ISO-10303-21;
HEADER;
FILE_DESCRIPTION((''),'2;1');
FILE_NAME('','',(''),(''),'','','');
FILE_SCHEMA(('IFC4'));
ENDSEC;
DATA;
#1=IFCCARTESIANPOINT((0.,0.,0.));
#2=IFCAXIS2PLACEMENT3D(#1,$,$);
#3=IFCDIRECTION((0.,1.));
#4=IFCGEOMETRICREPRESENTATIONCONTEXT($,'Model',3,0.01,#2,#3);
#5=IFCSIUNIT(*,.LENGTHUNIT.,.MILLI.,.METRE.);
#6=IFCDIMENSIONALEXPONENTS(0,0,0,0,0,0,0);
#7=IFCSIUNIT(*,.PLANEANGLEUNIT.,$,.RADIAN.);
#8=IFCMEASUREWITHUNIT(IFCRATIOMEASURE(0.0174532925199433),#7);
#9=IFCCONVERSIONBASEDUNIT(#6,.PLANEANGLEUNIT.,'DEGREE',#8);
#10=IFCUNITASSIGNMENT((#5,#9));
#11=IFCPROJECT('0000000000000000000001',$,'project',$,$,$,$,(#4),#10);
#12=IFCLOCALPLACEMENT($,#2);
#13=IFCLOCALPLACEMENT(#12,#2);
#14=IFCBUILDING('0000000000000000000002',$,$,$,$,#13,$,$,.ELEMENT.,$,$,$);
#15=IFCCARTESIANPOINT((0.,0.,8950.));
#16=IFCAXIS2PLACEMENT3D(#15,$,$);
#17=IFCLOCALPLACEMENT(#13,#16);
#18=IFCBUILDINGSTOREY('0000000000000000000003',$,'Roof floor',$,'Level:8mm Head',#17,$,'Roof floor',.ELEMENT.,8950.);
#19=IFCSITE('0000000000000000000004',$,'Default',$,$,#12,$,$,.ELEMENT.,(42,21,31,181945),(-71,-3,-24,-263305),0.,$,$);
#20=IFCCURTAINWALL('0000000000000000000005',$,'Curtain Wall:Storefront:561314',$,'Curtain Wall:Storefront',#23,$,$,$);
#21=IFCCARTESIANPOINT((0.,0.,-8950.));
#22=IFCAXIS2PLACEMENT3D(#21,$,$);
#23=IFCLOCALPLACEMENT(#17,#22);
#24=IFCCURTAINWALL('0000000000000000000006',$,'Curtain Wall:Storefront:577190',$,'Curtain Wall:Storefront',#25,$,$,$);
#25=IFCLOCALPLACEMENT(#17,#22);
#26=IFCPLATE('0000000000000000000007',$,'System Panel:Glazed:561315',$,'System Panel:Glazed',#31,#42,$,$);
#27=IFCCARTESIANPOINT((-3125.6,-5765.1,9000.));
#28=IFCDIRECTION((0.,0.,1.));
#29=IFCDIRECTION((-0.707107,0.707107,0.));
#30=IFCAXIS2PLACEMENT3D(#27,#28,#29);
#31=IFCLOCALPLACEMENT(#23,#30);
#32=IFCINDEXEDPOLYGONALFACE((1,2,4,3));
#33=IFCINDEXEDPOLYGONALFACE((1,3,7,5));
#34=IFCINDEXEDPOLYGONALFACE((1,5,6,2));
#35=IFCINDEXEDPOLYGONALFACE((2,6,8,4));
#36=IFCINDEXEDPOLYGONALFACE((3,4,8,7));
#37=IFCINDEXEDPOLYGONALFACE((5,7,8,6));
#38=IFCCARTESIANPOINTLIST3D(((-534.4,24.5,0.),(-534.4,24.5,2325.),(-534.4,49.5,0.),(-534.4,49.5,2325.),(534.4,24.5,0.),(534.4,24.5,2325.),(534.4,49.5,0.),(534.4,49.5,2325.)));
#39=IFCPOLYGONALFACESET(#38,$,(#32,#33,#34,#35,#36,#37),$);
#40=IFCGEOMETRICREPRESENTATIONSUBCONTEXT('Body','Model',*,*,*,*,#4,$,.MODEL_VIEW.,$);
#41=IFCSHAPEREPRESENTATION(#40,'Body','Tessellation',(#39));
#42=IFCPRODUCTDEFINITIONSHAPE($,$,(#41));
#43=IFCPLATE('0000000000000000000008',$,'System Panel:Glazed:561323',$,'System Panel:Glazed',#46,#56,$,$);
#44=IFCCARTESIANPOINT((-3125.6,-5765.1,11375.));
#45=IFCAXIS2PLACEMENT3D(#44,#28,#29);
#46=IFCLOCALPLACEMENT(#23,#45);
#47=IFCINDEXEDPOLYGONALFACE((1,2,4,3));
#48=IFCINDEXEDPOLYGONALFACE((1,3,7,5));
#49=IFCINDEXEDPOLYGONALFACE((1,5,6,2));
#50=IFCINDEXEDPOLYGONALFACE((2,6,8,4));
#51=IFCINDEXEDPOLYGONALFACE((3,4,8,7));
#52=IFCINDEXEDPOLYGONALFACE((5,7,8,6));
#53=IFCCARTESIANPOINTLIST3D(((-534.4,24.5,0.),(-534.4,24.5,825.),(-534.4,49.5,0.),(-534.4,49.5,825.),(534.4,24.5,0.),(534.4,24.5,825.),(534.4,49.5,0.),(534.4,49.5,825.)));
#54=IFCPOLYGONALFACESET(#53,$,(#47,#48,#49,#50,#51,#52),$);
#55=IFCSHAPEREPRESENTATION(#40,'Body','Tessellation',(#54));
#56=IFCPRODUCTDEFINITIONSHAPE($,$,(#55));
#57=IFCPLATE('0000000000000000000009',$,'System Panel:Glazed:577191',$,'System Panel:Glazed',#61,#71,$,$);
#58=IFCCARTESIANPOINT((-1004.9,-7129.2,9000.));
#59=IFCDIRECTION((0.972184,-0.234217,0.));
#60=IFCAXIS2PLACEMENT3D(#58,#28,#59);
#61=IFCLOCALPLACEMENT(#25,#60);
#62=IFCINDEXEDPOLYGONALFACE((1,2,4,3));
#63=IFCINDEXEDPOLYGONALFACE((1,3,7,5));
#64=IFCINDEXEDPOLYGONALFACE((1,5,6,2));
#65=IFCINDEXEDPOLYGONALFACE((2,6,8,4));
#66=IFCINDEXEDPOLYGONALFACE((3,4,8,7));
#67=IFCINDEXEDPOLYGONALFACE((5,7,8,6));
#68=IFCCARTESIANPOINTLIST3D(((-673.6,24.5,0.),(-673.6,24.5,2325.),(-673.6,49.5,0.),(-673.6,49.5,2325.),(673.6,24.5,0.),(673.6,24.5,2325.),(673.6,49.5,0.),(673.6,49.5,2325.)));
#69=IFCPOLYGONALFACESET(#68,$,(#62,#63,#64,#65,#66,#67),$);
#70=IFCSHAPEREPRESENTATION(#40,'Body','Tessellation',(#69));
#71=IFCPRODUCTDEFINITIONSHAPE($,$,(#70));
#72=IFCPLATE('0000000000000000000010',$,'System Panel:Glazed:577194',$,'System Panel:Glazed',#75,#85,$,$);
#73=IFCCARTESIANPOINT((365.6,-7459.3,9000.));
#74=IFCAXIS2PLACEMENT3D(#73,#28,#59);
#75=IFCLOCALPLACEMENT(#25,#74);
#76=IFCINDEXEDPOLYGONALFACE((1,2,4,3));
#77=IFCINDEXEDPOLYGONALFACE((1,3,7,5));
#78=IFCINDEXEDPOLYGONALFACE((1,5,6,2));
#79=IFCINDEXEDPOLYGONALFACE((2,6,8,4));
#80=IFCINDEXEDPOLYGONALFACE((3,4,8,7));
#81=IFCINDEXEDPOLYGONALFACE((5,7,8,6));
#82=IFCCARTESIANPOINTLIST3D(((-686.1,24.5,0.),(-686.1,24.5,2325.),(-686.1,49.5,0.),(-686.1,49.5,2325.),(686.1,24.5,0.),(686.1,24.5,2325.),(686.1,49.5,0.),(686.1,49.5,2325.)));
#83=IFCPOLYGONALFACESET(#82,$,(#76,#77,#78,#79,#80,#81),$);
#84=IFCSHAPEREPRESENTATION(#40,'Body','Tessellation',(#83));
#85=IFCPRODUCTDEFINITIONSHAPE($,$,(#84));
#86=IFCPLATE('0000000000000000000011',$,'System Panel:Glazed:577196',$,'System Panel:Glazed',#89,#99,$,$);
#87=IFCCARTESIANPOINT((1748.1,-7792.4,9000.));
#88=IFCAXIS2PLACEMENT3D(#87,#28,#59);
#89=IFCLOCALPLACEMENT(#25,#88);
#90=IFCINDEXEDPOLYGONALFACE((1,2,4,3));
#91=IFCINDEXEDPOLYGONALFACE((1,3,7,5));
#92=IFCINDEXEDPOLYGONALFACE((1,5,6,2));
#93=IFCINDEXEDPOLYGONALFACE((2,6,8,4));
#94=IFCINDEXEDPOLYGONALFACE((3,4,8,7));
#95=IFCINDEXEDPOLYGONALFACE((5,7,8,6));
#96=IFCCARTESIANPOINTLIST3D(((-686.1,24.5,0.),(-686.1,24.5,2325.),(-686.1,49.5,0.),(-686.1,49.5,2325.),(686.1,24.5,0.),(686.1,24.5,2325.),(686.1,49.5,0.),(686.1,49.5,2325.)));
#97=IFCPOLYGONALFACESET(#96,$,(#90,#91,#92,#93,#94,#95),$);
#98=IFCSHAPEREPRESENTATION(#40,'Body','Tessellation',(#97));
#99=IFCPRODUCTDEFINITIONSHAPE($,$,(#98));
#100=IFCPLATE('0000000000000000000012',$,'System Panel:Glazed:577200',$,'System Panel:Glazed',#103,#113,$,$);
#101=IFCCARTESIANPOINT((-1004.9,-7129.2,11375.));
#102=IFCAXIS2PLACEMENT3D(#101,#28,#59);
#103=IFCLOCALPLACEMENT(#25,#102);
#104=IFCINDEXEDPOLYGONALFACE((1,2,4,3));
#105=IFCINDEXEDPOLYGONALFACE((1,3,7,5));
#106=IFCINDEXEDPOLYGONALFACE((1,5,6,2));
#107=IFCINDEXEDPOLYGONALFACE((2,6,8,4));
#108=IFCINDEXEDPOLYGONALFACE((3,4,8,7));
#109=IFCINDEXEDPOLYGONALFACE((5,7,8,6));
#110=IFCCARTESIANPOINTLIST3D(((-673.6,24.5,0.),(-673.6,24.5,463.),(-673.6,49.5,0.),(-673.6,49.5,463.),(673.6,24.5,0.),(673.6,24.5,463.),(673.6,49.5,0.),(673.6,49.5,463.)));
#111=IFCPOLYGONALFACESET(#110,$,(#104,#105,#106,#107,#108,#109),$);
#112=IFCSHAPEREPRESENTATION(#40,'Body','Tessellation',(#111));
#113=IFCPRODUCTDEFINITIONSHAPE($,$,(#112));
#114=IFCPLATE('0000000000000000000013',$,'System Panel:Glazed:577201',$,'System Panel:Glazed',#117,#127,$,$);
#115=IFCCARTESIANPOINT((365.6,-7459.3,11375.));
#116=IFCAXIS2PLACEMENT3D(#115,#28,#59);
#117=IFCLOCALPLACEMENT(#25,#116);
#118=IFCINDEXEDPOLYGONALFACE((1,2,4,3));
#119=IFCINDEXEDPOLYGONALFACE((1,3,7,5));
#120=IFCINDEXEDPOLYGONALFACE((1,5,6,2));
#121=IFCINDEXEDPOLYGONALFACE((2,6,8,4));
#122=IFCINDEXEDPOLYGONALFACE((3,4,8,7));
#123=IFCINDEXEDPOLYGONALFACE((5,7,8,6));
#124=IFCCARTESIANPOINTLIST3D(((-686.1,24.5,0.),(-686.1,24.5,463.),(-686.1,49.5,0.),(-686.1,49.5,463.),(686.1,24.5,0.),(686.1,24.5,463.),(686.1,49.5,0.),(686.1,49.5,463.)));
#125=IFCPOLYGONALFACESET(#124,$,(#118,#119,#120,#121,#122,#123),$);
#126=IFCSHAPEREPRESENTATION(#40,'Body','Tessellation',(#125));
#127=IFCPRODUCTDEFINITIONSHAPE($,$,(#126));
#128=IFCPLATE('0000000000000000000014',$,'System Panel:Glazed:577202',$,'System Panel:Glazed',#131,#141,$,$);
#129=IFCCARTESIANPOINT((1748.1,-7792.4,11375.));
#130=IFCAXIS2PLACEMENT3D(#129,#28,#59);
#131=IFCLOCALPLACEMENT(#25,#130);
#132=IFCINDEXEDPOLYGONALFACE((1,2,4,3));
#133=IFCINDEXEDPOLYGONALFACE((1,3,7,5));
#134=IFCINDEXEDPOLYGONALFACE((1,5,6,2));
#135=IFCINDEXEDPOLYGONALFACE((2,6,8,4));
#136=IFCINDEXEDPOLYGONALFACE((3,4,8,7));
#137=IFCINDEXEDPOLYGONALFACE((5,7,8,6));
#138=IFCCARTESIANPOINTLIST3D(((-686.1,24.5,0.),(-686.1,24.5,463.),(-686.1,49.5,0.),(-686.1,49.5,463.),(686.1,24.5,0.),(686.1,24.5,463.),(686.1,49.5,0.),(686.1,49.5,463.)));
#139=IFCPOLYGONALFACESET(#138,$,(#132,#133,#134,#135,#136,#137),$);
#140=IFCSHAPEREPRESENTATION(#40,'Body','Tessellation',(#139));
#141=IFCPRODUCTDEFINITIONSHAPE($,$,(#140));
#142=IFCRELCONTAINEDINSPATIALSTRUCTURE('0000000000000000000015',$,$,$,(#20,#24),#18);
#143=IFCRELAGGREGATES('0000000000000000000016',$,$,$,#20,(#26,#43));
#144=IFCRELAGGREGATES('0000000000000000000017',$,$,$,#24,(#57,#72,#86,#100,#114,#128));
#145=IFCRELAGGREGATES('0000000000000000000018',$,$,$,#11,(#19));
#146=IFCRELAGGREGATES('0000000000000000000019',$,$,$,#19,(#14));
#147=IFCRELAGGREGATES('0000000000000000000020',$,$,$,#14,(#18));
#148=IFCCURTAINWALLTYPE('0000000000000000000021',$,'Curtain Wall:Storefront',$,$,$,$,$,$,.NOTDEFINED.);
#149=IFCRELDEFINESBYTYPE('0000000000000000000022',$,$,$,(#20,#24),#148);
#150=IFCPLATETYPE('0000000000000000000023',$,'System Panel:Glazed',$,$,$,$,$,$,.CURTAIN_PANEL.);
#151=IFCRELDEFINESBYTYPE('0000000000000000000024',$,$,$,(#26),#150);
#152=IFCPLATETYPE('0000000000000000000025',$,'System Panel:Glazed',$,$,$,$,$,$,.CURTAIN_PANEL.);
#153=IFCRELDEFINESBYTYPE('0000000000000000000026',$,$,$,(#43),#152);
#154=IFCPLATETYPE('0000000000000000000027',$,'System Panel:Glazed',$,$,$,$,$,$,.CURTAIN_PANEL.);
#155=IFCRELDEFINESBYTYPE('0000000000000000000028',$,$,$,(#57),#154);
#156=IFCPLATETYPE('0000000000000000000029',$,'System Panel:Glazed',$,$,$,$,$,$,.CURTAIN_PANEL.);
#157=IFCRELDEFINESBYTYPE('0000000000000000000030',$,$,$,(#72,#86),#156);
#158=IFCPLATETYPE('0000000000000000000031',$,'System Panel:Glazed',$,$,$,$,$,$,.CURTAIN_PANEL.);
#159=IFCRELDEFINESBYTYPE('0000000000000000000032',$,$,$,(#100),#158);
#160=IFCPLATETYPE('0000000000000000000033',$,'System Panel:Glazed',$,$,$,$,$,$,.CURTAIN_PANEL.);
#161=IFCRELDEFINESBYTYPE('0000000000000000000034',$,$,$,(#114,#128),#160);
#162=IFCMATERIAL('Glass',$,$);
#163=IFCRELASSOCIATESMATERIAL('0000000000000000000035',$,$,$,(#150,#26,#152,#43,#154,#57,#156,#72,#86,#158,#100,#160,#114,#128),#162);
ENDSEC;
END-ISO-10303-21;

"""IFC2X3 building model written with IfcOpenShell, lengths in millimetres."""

from ifc_helpers import new_model, entity, si_unit, converted_unit, direction, frame, frame_2d, origin, origin_2d_with_axis, place, context, subcontext, project, spatial, rectangle, extrude, source, transform, mapped, material, type_object, type_shapes, element, aggregate, save


model = new_model("IFC2X3")

# Units and contexts
model_context = context("Model", 3, precision=0.01, world=origin(), true_north=direction((0.0, 1.0)))
body_context = subcontext(model_context, "Body", "Model", "MODEL_VIEW")
ifc_project = project(units=[si_unit("LENGTHUNIT", "METRE", prefix="MILLI"), converted_unit("PLANEANGLEUNIT", "DEGREE", entity("IfcRatioMeasure", 0.0174532925199433), si_unit("PLANEANGLEUNIT", "RADIAN"), dimensions=[0, 0, 0, 0, 0, 0, 0])], contexts=[model_context])

# Site, building, storey
site_placement = place(None, origin())
site = spatial("IfcSite", under=ifc_project, at=site_placement, Name="Default", CompositionType="ELEMENT", RefLatitude=(42, 21, 31, 181945), RefLongitude=(-71, -3, -24, -263305), RefElevation=0.0)
building_placement = place(site_placement, origin())
building = spatial("IfcBuilding", under=site, at=building_placement, CompositionType="ELEMENT")
storey_placement = place(building_placement, frame((0.0, 0.0, 8950.0)))
storey = spatial("IfcBuildingStorey", under=building, at=storey_placement, Name="Roof floor", ObjectType="Level:8mm Head", LongName="Roof floor", CompositionType="ELEMENT", Elevation=8950.0)

# Curtain walls
curtain_wall_type = type_object("IfcCurtainWallType", Name="Curtain Wall:Storefront", PredefinedType="NOTDEFINED")
curtain_wall_1_placement = place(storey_placement, frame((0.0, 0.0, -8950.0)))
curtain_wall_1 = element("IfcCurtainWall", 1, at=curtain_wall_1_placement, inside=storey, type_object=curtain_wall_type, Name="Curtain Wall:Storefront:561314", ObjectType="Curtain Wall:Storefront")
curtain_wall_2_placement = place(storey_placement, frame((0.0, 0.0, -8950.0)))
curtain_wall_2 = element("IfcCurtainWall", 2, at=curtain_wall_2_placement, inside=storey, type_object=curtain_wall_type, Name="Curtain Wall:Storefront:577190", ObjectType="Curtain Wall:Storefront")

# Plates
ifc_material_1 = material(Name="Glass")
plate_type_1 = type_object("IfcPlateType", Name="System Panel:Glazed", PredefinedType="CURTAIN_PANEL", material=ifc_material_1)
shared_shape_1 = source(origin(), body_context, "Body", "SweptSolid", [
    extrude(rectangle(XDim=25.0, YDim=1068.7, at=frame_2d((0.0, 0.0), x_axis=(1.0, 0.0))), frame((0.0, 37.0, 0.0), z_axis=(0.0, 0.0, 1.0), x_axis=(0.0, 1.0, 0.0)), (0.0, 0.0, 1.0), 2325.0),
])
type_shapes(plate_type_1, [shared_shape_1])
plate_1_placement = place(curtain_wall_1_placement, frame((-3125.6, -5765.1, 9000.0), z_axis=(0.0, 0.0, 1.0), x_axis=(-0.707107, 0.707107, 0.0)))
plate_1 = element("IfcPlate", 3, at=plate_1_placement, type_object=plate_type_1, material=ifc_material_1, Name="System Panel:Glazed:561315", ObjectType="System Panel:Glazed", context=body_context, shape_type="MappedRepresentation", body=[
    mapped(shared_shape_1, transform((0.0, 0.0, 0.0), scale=1.0)),
])
plate_type_2 = type_object("IfcPlateType", Name="System Panel:Glazed", PredefinedType="CURTAIN_PANEL", material=ifc_material_1)
shared_shape_2 = source(origin(), body_context, "Body", "SweptSolid", [
    extrude(rectangle(XDim=25.0, YDim=1068.7, at=frame_2d((0.0, 0.0), x_axis=(1.0, 0.0))), frame((0.0, 37.0, 0.0), z_axis=(0.0, 0.0, 1.0), x_axis=(0.0, 1.0, 0.0)), (0.0, 0.0, 1.0), 825.0),
])
type_shapes(plate_type_2, [shared_shape_2])
plate_2_placement = place(curtain_wall_1_placement, frame((-3125.6, -5765.1, 11375.0), z_axis=(0.0, 0.0, 1.0), x_axis=(-0.707107, 0.707107, 0.0)))
plate_2 = element("IfcPlate", 4, at=plate_2_placement, type_object=plate_type_2, material=ifc_material_1, Name="System Panel:Glazed:561323", ObjectType="System Panel:Glazed", context=body_context, shape_type="MappedRepresentation", body=[
    mapped(shared_shape_2, transform((0.0, 0.0, 0.0), scale=1.0)),
])
aggregate(curtain_wall_1, [plate_1, plate_2])
plate_type_3 = type_object("IfcPlateType", Name="System Panel:Glazed", PredefinedType="CURTAIN_PANEL", material=ifc_material_1)
shared_shape_3 = source(origin(), body_context, "Body", "SweptSolid", [
    extrude(rectangle(XDim=25.0, YDim=1347.1, at=origin_2d_with_axis()), frame((0.0, 37.0, 0.0), z_axis=(0.0, 0.0, 1.0), x_axis=(0.0, 1.0, 0.0)), (0.0, 0.0, 1.0), 2325.0),
])
type_shapes(plate_type_3, [shared_shape_3])
plate_3_placement = place(curtain_wall_2_placement, frame((-1004.9, -7129.2, 9000.0), z_axis=(0.0, 0.0, 1.0), x_axis=(0.972184, -0.234217, 0.0)))
plate_3 = element("IfcPlate", 5, at=plate_3_placement, type_object=plate_type_3, material=ifc_material_1, Name="System Panel:Glazed:577191", ObjectType="System Panel:Glazed", context=body_context, shape_type="MappedRepresentation", body=[
    mapped(shared_shape_3, transform((0.0, 0.0, 0.0), scale=1.0)),
])
plate_type_4 = type_object("IfcPlateType", Name="System Panel:Glazed", PredefinedType="CURTAIN_PANEL", material=ifc_material_1)
shared_shape_4 = source(origin(), body_context, "Body", "SweptSolid", [
    extrude(rectangle(XDim=25.0, YDim=1372.1, at=origin_2d_with_axis()), frame((0.0, 37.0, 0.0), z_axis=(0.0, 0.0, 1.0), x_axis=(0.0, 1.0, 0.0)), (0.0, 0.0, 1.0), 2325.0),
])
type_shapes(plate_type_4, [shared_shape_4])
plate_4_placement = place(curtain_wall_2_placement, frame((365.6, -7459.3, 9000.0), z_axis=(0.0, 0.0, 1.0), x_axis=(0.972184, -0.234217, 0.0)))
plate_4 = element("IfcPlate", 6, at=plate_4_placement, type_object=plate_type_4, material=ifc_material_1, Name="System Panel:Glazed:577194", ObjectType="System Panel:Glazed", context=body_context, shape_type="MappedRepresentation", body=[
    mapped(shared_shape_4, transform((0.0, 0.0, 0.0), scale=1.0)),
])
plate_5_placement = place(curtain_wall_2_placement, frame((1748.1, -7792.4, 9000.0), z_axis=(0.0, 0.0, 1.0), x_axis=(0.972184, -0.234217, 0.0)))
plate_5 = element("IfcPlate", 7, at=plate_5_placement, type_object=plate_type_4, material=ifc_material_1, Name="System Panel:Glazed:577196", ObjectType="System Panel:Glazed", context=body_context, shape_type="MappedRepresentation", body=[
    mapped(shared_shape_4, transform((0.0, 0.0, 0.0), scale=1.0)),
])
plate_type_5 = type_object("IfcPlateType", Name="System Panel:Glazed", PredefinedType="CURTAIN_PANEL", material=ifc_material_1)
shared_shape_5 = source(origin(), body_context, "Body", "SweptSolid", [
    extrude(rectangle(XDim=25.0, YDim=1347.1, at=origin_2d_with_axis()), frame((0.0, 37.0, 0.0), z_axis=(0.0, 0.0, 1.0), x_axis=(0.0, 1.0, 0.0)), (0.0, 0.0, 1.0), 463.0),
])
type_shapes(plate_type_5, [shared_shape_5])
plate_6_placement = place(curtain_wall_2_placement, frame((-1004.9, -7129.2, 11375.0), z_axis=(0.0, 0.0, 1.0), x_axis=(0.972184, -0.234217, 0.0)))
plate_6 = element("IfcPlate", 8, at=plate_6_placement, type_object=plate_type_5, material=ifc_material_1, Name="System Panel:Glazed:577200", ObjectType="System Panel:Glazed", context=body_context, shape_type="MappedRepresentation", body=[
    mapped(shared_shape_5, transform((0.0, 0.0, 0.0), scale=1.0)),
])
plate_type_6 = type_object("IfcPlateType", Name="System Panel:Glazed", PredefinedType="CURTAIN_PANEL", material=ifc_material_1)
shared_shape_6 = source(origin(), body_context, "Body", "SweptSolid", [
    extrude(rectangle(XDim=25.0, YDim=1372.1, at=origin_2d_with_axis()), frame((0.0, 37.0, 0.0), z_axis=(0.0, 0.0, 1.0), x_axis=(0.0, 1.0, 0.0)), (0.0, 0.0, 1.0), 463.0),
])
type_shapes(plate_type_6, [shared_shape_6])
plate_7_placement = place(curtain_wall_2_placement, frame((365.6, -7459.3, 11375.0), z_axis=(0.0, 0.0, 1.0), x_axis=(0.972184, -0.234217, 0.0)))
plate_7 = element("IfcPlate", 9, at=plate_7_placement, type_object=plate_type_6, material=ifc_material_1, Name="System Panel:Glazed:577201", ObjectType="System Panel:Glazed", context=body_context, shape_type="MappedRepresentation", body=[
    mapped(shared_shape_6, transform((0.0, 0.0, 0.0), scale=1.0)),
])
plate_8_placement = place(curtain_wall_2_placement, frame((1748.1, -7792.4, 11375.0), z_axis=(0.0, 0.0, 1.0), x_axis=(0.972184, -0.234217, 0.0)))
plate_8 = element("IfcPlate", 10, at=plate_8_placement, type_object=plate_type_6, material=ifc_material_1, Name="System Panel:Glazed:577202", ObjectType="System Panel:Glazed", context=body_context, shape_type="MappedRepresentation", body=[
    mapped(shared_shape_6, transform((0.0, 0.0, 0.0), scale=1.0)),
])
aggregate(curtain_wall_2, [plate_3, plate_4, plate_5, plate_6, plate_7, plate_8])

save(model, "model.ifc")
